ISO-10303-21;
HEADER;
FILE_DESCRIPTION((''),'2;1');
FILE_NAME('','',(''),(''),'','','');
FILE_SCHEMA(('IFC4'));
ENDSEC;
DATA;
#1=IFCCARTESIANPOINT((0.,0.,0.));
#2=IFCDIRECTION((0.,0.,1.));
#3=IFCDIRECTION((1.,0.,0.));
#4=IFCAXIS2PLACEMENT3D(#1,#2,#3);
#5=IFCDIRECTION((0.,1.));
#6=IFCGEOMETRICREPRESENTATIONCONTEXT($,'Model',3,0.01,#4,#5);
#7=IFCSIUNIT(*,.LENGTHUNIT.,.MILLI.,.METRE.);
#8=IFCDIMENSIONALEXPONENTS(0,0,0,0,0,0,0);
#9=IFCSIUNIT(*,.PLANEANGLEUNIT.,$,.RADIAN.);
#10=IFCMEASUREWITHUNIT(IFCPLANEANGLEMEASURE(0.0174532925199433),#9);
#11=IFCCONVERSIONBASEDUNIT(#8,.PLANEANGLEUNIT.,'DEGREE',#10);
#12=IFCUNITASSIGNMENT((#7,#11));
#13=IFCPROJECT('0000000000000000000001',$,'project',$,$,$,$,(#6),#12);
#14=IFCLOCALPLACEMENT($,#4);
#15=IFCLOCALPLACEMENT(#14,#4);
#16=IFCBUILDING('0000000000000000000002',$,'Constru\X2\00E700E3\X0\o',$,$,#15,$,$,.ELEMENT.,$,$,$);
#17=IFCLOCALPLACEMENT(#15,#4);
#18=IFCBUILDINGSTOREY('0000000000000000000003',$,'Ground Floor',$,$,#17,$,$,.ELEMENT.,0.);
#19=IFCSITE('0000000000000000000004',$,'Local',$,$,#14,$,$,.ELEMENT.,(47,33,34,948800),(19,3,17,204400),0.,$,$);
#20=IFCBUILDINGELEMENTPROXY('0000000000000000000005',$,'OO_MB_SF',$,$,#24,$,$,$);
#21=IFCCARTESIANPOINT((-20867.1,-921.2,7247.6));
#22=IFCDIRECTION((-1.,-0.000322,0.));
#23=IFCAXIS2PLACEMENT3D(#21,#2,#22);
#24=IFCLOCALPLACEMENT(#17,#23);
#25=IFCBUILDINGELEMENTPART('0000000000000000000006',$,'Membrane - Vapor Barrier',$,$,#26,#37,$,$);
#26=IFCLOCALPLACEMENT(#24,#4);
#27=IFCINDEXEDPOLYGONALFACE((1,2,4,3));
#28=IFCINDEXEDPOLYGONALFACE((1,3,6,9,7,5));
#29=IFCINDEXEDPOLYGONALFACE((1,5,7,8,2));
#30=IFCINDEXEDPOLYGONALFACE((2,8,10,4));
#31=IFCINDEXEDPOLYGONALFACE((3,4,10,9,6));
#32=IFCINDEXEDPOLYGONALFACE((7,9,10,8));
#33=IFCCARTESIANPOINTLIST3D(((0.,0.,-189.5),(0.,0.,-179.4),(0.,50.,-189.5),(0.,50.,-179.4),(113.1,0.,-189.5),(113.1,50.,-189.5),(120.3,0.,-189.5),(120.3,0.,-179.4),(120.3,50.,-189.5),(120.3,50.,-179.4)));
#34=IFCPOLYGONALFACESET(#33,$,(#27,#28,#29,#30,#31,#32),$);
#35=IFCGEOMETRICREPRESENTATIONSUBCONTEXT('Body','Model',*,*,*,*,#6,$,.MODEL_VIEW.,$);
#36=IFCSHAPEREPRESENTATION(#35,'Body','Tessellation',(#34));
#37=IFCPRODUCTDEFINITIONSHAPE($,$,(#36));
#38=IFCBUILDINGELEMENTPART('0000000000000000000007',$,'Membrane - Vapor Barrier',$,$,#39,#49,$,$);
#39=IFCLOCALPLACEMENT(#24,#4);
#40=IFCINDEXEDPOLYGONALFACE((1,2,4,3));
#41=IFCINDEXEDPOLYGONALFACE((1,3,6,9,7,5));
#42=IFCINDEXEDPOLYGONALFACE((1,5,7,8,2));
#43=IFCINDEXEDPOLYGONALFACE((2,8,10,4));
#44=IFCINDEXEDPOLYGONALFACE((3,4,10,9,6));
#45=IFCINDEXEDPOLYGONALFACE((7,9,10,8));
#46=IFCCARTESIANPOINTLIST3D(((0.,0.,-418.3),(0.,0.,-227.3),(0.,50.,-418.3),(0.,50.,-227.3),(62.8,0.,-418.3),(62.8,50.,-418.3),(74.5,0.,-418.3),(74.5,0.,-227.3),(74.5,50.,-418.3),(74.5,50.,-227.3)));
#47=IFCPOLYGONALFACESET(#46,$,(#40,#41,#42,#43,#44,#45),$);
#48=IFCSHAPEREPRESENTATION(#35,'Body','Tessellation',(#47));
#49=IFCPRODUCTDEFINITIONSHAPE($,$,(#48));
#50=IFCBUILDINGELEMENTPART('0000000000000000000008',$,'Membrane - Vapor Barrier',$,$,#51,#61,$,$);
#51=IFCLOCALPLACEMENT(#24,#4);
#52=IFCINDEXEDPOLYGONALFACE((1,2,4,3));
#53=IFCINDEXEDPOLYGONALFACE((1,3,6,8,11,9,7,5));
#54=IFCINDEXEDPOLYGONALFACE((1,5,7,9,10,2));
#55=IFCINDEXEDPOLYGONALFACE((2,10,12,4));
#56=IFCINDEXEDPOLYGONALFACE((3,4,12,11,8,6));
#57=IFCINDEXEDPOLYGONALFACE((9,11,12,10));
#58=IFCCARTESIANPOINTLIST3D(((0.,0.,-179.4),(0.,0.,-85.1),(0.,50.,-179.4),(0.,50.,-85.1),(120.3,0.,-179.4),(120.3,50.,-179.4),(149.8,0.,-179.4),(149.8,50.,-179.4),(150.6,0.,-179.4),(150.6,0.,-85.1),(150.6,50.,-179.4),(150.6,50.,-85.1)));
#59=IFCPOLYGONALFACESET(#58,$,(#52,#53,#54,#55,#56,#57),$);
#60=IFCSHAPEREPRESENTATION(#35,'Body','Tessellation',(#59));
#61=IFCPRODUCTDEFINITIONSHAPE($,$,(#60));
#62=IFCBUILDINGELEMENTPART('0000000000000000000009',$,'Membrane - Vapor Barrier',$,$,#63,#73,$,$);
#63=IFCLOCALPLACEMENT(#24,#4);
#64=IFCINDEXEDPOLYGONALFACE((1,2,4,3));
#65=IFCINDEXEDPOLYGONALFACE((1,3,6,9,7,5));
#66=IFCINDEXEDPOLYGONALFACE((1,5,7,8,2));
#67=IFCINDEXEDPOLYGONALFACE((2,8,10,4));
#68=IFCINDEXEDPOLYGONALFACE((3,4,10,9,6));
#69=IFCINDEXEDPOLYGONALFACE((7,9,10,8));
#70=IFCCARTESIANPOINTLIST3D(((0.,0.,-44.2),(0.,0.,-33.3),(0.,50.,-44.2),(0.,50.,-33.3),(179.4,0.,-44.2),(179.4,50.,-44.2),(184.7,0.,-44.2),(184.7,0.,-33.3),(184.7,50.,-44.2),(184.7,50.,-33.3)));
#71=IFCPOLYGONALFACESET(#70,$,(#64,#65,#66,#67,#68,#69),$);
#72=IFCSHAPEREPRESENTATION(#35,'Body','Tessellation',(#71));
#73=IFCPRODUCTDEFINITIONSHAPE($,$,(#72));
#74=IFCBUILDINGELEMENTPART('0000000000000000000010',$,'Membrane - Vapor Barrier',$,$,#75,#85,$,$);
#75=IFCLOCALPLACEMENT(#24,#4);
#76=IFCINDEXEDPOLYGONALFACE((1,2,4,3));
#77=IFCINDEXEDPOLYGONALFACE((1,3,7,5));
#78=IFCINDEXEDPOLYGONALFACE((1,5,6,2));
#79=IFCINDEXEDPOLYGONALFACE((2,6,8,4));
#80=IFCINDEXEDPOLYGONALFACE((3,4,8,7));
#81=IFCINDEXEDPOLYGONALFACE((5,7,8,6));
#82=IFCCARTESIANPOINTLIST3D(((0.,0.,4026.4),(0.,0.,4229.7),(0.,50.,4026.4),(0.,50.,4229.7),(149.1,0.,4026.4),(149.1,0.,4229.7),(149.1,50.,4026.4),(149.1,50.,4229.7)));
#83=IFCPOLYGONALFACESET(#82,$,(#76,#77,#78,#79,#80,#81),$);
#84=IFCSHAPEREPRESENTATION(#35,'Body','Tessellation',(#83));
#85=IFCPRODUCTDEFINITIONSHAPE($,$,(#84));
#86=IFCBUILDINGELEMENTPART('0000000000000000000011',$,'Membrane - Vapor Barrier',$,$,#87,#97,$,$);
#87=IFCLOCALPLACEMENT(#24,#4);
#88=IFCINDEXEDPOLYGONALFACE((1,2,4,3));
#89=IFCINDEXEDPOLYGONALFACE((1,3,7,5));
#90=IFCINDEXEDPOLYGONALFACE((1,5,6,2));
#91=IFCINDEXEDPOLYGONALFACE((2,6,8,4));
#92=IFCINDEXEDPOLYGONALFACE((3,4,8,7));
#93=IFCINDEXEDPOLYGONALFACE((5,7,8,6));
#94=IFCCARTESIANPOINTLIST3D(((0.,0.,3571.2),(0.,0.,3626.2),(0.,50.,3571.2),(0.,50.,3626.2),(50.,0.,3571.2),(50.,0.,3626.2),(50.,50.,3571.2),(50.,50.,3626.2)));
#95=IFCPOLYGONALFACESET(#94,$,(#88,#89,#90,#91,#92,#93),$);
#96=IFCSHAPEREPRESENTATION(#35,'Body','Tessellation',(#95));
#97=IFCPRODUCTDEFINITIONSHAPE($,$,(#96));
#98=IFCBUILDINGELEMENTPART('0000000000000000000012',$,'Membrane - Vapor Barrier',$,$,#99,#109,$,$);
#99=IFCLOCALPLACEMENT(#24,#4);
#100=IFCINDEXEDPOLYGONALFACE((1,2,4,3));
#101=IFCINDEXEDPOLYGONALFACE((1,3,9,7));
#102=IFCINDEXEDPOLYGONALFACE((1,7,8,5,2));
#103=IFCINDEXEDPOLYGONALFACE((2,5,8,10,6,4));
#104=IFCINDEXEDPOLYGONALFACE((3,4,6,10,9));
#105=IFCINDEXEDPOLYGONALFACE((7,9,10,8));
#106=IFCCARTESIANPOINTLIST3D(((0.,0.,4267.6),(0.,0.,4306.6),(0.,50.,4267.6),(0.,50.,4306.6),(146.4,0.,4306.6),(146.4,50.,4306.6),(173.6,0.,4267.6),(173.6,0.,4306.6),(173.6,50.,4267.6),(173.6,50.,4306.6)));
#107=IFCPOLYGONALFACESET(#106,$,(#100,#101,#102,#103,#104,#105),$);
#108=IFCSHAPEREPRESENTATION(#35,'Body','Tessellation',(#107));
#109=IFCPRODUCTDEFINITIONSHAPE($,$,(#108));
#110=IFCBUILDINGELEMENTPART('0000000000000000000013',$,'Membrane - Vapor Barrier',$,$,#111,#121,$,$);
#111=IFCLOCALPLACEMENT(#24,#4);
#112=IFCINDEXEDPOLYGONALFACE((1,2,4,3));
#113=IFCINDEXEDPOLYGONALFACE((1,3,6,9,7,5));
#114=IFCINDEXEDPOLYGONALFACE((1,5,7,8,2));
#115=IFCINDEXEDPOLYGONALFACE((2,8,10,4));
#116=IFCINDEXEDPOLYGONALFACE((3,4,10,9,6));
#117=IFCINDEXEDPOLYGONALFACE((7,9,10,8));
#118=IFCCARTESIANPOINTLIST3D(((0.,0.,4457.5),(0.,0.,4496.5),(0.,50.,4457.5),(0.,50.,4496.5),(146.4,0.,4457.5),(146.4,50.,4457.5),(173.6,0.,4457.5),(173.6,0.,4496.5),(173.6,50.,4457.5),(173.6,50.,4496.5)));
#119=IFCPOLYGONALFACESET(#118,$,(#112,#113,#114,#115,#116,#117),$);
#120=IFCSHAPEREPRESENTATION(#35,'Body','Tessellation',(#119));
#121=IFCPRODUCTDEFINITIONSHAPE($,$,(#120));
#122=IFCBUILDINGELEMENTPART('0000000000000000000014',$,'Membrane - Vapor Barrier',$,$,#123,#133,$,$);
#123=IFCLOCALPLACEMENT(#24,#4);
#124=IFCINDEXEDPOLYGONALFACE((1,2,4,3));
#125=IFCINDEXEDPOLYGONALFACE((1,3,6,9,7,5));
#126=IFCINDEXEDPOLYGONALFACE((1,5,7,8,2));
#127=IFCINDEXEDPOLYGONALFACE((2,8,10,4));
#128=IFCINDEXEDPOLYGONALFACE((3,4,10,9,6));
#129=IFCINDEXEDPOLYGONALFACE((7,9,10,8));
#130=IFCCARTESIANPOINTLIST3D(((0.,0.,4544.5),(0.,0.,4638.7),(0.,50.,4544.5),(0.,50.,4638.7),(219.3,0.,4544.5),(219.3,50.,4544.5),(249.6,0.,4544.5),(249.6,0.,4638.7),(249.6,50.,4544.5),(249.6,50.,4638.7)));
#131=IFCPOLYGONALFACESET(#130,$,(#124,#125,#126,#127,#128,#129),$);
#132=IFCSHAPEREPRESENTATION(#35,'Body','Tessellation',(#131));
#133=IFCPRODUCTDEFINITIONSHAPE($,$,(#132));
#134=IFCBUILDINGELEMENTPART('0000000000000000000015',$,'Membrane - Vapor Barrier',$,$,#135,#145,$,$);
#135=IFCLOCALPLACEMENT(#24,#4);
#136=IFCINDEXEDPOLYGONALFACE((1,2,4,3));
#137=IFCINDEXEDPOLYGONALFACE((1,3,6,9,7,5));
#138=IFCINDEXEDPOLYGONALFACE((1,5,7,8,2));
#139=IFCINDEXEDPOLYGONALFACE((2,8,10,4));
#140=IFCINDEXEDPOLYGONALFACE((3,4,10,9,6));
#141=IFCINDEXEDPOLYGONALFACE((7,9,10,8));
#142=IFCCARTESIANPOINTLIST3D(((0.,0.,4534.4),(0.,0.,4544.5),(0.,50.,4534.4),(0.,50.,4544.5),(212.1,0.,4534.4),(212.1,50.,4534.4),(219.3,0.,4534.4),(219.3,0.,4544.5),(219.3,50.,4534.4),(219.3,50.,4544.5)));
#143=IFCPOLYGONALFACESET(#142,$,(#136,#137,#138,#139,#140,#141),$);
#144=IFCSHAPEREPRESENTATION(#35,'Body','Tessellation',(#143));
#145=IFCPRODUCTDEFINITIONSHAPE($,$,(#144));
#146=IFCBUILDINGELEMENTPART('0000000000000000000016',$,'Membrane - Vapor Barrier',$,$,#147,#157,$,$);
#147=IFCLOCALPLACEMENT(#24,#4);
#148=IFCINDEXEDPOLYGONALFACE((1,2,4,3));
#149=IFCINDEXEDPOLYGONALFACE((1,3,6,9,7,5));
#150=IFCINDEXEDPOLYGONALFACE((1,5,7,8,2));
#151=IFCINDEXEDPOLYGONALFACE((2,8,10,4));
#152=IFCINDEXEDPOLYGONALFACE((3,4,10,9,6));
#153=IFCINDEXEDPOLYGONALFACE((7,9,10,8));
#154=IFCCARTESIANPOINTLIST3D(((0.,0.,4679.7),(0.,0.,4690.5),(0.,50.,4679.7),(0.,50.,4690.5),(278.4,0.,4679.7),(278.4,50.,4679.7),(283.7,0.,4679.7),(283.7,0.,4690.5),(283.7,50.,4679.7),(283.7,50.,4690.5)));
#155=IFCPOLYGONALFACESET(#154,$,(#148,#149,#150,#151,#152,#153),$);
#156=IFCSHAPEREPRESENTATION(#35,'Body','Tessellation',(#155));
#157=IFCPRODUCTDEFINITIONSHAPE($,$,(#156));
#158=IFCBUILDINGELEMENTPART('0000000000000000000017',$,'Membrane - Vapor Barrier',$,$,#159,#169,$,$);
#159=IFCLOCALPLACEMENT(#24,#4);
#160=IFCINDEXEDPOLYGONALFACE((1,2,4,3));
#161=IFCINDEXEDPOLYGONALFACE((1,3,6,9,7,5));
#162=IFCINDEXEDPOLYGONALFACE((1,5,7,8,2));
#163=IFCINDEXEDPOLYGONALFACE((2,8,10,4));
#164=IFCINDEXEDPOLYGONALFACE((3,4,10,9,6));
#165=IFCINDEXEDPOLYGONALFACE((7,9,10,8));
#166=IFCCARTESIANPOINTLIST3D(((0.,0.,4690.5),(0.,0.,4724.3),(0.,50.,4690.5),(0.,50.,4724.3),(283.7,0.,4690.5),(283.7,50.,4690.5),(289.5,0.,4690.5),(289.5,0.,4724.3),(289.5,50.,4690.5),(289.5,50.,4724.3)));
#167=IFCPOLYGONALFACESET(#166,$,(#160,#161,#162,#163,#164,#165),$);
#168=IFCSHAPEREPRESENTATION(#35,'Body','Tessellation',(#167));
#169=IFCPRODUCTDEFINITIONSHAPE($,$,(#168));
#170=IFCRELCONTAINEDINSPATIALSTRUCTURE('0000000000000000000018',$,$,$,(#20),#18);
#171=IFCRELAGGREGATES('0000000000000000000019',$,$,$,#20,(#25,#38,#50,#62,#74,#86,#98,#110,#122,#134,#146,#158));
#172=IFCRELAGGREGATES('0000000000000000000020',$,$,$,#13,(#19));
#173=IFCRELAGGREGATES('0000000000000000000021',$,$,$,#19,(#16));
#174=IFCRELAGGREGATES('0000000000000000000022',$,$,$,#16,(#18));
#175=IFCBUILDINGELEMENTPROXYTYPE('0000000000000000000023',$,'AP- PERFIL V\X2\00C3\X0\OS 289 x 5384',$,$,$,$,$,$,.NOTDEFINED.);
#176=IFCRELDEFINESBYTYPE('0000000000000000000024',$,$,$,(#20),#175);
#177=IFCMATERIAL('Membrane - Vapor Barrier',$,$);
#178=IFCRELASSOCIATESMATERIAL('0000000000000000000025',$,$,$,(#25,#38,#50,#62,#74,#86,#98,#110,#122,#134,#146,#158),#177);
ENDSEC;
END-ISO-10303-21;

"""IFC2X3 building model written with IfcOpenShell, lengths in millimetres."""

from ifc_helpers import new_model, entity, si_unit, converted_unit, direction, frame, origin_with_axes, place, context, subcontext, project, spatial, polyline, outline, extrude, material, type_object, element, aggregate, save


model = new_model("IFC2X3")

# Units and contexts
model_context = context("Model", 3, precision=0.01, world=origin_with_axes(), true_north=direction((0.0, 1.0)))
body_context = subcontext(model_context, "Body", "Model", "MODEL_VIEW")
ifc_project = project(units=[si_unit("LENGTHUNIT", "METRE", prefix="MILLI"), converted_unit("PLANEANGLEUNIT", "DEGREE", entity("IfcPlaneAngleMeasure", 0.0174532925199433), si_unit("PLANEANGLEUNIT", "RADIAN"), dimensions=[0, 0, 0, 0, 0, 0, 0])], contexts=[model_context])

# Site, building, storey
site_placement = place(None, origin_with_axes())
site = spatial("IfcSite", under=ifc_project, at=site_placement, Name="Local", CompositionType="ELEMENT", RefLatitude=(47, 33, 34, 948800), RefLongitude=(19, 3, 17, 204400), RefElevation=0.0)
building_placement = place(site_placement, origin_with_axes())
building = spatial("IfcBuilding", under=site, at=building_placement, Name="Construção", CompositionType="ELEMENT")
storey_placement = place(building_placement, origin_with_axes())
storey = spatial("IfcBuildingStorey", under=building, at=storey_placement, Name="Ground Floor", CompositionType="ELEMENT", Elevation=0.0)

# Building element proxy, building element parts
building_element_proxy_type = type_object("IfcBuildingElementProxyType", Name="AP- PERFIL VÃOS 289 x 5384", PredefinedType="NOTDEFINED")
ifc_material = material(Name="Membrane - Vapor Barrier")
proxy_1_placement = place(storey_placement, frame((-20867.1, -921.2, 7247.6), z_axis=(0.0, 0.0, 1.0), x_axis=(-1.0, -0.000322, 0.0)))
proxy_1 = element("IfcBuildingElementProxy", 1, at=proxy_1_placement, inside=storey, type_object=building_element_proxy_type, Name="OO_MB_SF")
building_element_part_1_placement = place(proxy_1_placement, origin_with_axes())
building_element_part_1 = element("IfcBuildingElementPart", 2, at=building_element_part_1_placement, material=ifc_material, Name="Membrane - Vapor Barrier", context=body_context, shape_type="SweptSolid", body=[
    extrude(outline(polyline([(120.3, -179.4), (0.0, -179.4), (0.0, -189.5), (113.1, -189.5), (120.3, -189.5), (120.3, -179.4)])), frame((0.0, 50.0, 0.0), z_axis=(0.0, -1.0, 0.0), x_axis=(1.0, 0.0, 0.0)), (0.0, 0.0, 1.0), 50.0),
])
building_element_part_2_placement = place(proxy_1_placement, origin_with_axes())
building_element_part_2 = element("IfcBuildingElementPart", 3, at=building_element_part_2_placement, material=ifc_material, Name="Membrane - Vapor Barrier", context=body_context, shape_type="SweptSolid", body=[
    extrude(outline(polyline([(0.0, -227.3), (0.0, -418.3), (62.8, -418.3), (74.5, -418.3), (74.5, -227.3), (0.0, -227.3)])), frame((0.0, 50.0, 0.0), z_axis=(0.0, -1.0, 0.0), x_axis=(1.0, 0.0, 0.0)), (0.0, 0.0, 1.0), 50.0),
])
building_element_part_3_placement = place(proxy_1_placement, origin_with_axes())
building_element_part_3 = element("IfcBuildingElementPart", 4, at=building_element_part_3_placement, material=ifc_material, Name="Membrane - Vapor Barrier", context=body_context, shape_type="SweptSolid", body=[
    extrude(outline(polyline([(0.0, -85.1), (0.0, -179.4), (120.3, -179.4), (149.8, -179.4), (150.6, -179.4), (150.6, -85.1), (0.0, -85.1)])), frame((0.0, 50.0, 0.0), z_axis=(0.0, -1.0, 0.0), x_axis=(1.0, 0.0, 0.0)), (0.0, 0.0, 1.0), 50.0),
])
building_element_part_4_placement = place(proxy_1_placement, origin_with_axes())
building_element_part_4 = element("IfcBuildingElementPart", 5, at=building_element_part_4_placement, material=ifc_material, Name="Membrane - Vapor Barrier", context=body_context, shape_type="SweptSolid", body=[
    extrude(outline(polyline([(184.7, -33.3), (0.0, -33.3), (0.0, -44.2), (179.4, -44.2), (184.7, -44.2), (184.7, -33.3)])), frame((0.0, 50.0, 0.0), z_axis=(0.0, -1.0, 0.0), x_axis=(1.0, 0.0, 0.0)), (0.0, 0.0, 1.0), 50.0),
])
building_element_part_5_placement = place(proxy_1_placement, origin_with_axes())
building_element_part_5 = element("IfcBuildingElementPart", 6, at=building_element_part_5_placement, material=ifc_material, Name="Membrane - Vapor Barrier", context=body_context, shape_type="SweptSolid", body=[
    extrude(outline(polyline([(149.1, 4229.7), (0.0, 4229.7), (0.0, 4026.4), (149.1, 4026.4), (149.1, 4229.7)])), frame((0.0, 50.0, 0.0), z_axis=(0.0, -1.0, 0.0), x_axis=(1.0, 0.0, 0.0)), (0.0, 0.0, 1.0), 50.0),
])
building_element_part_6_placement = place(proxy_1_placement, origin_with_axes())
building_element_part_6 = element("IfcBuildingElementPart", 7, at=building_element_part_6_placement, material=ifc_material, Name="Membrane - Vapor Barrier", context=body_context, shape_type="SweptSolid", body=[
    extrude(outline(polyline([(0.0, 3571.2), (50.0, 3571.2), (50.0, 3626.2), (0.0, 3626.2), (0.0, 3571.2)])), frame((0.0, 50.0, 0.0), z_axis=(0.0, -1.0, 0.0), x_axis=(1.0, 0.0, 0.0)), (0.0, 0.0, 1.0), 50.0),
])
building_element_part_7_placement = place(proxy_1_placement, origin_with_axes())
building_element_part_7 = element("IfcBuildingElementPart", 8, at=building_element_part_7_placement, material=ifc_material, Name="Membrane - Vapor Barrier", context=body_context, shape_type="SweptSolid", body=[
    extrude(outline(polyline([(0.0, 4306.6), (0.0, 4267.6), (173.6, 4267.6), (173.6, 4306.6), (146.4, 4306.6), (0.0, 4306.6)])), frame((0.0, 50.0, 0.0), z_axis=(0.0, -1.0, 0.0), x_axis=(1.0, 0.0, 0.0)), (0.0, 0.0, 1.0), 50.0),
])
building_element_part_8_placement = place(proxy_1_placement, origin_with_axes())
building_element_part_8 = element("IfcBuildingElementPart", 9, at=building_element_part_8_placement, material=ifc_material, Name="Membrane - Vapor Barrier", context=body_context, shape_type="SweptSolid", body=[
    extrude(outline(polyline([(173.6, 4496.5), (0.0, 4496.5), (0.0, 4457.5), (146.4, 4457.5), (173.6, 4457.5), (173.6, 4496.5)])), frame((0.0, 50.0, 0.0), z_axis=(0.0, -1.0, 0.0), x_axis=(1.0, 0.0, 0.0)), (0.0, 0.0, 1.0), 50.0),
])
building_element_part_9_placement = place(proxy_1_placement, origin_with_axes())
building_element_part_9 = element("IfcBuildingElementPart", 10, at=building_element_part_9_placement, material=ifc_material, Name="Membrane - Vapor Barrier", context=body_context, shape_type="SweptSolid", body=[
    extrude(outline(polyline([(249.6, 4638.7), (0.0, 4638.7), (0.0, 4544.5), (219.3, 4544.5), (249.6, 4544.5), (249.6, 4638.7)])), frame((0.0, 50.0, 0.0), z_axis=(0.0, -1.0, 0.0), x_axis=(1.0, 0.0, 0.0)), (0.0, 0.0, 1.0), 50.0),
])
building_element_part_10_placement = place(proxy_1_placement, origin_with_axes())
building_element_part_10 = element("IfcBuildingElementPart", 11, at=building_element_part_10_placement, material=ifc_material, Name="Membrane - Vapor Barrier", context=body_context, shape_type="SweptSolid", body=[
    extrude(outline(polyline([(0.0, 4534.4), (212.1, 4534.4), (219.3, 4534.4), (219.3, 4544.5), (0.0, 4544.5), (0.0, 4534.4)])), frame((0.0, 50.0, 0.0), z_axis=(0.0, -1.0, 0.0), x_axis=(1.0, 0.0, 0.0)), (0.0, 0.0, 1.0), 50.0),
])
building_element_part_11_placement = place(proxy_1_placement, origin_with_axes())
building_element_part_11 = element("IfcBuildingElementPart", 12, at=building_element_part_11_placement, material=ifc_material, Name="Membrane - Vapor Barrier", context=body_context, shape_type="SweptSolid", body=[
    extrude(outline(polyline([(0.0, 4679.7), (278.4, 4679.7), (283.7, 4679.7), (283.7, 4690.5), (0.0, 4690.5), (0.0, 4679.7)])), frame((0.0, 50.0, 0.0), z_axis=(0.0, -1.0, 0.0), x_axis=(1.0, 0.0, 0.0)), (0.0, 0.0, 1.0), 50.0),
])
building_element_part_12_placement = place(proxy_1_placement, origin_with_axes())
building_element_part_12 = element("IfcBuildingElementPart", 13, at=building_element_part_12_placement, material=ifc_material, Name="Membrane - Vapor Barrier", context=body_context, shape_type="SweptSolid", body=[
    extrude(outline(polyline([(0.0, 4690.5), (283.7, 4690.5), (289.5, 4690.5), (289.5, 4724.3), (0.0, 4724.3), (0.0, 4690.5)])), frame((0.0, 50.0, 0.0), z_axis=(0.0, -1.0, 0.0), x_axis=(1.0, 0.0, 0.0)), (0.0, 0.0, 1.0), 50.0),
])
aggregate(proxy_1, [building_element_part_1, building_element_part_2, building_element_part_3, building_element_part_4, building_element_part_5, building_element_part_6, building_element_part_7, building_element_part_8, building_element_part_9, building_element_part_10, building_element_part_11, building_element_part_12])

save(model, "model.ifc")
